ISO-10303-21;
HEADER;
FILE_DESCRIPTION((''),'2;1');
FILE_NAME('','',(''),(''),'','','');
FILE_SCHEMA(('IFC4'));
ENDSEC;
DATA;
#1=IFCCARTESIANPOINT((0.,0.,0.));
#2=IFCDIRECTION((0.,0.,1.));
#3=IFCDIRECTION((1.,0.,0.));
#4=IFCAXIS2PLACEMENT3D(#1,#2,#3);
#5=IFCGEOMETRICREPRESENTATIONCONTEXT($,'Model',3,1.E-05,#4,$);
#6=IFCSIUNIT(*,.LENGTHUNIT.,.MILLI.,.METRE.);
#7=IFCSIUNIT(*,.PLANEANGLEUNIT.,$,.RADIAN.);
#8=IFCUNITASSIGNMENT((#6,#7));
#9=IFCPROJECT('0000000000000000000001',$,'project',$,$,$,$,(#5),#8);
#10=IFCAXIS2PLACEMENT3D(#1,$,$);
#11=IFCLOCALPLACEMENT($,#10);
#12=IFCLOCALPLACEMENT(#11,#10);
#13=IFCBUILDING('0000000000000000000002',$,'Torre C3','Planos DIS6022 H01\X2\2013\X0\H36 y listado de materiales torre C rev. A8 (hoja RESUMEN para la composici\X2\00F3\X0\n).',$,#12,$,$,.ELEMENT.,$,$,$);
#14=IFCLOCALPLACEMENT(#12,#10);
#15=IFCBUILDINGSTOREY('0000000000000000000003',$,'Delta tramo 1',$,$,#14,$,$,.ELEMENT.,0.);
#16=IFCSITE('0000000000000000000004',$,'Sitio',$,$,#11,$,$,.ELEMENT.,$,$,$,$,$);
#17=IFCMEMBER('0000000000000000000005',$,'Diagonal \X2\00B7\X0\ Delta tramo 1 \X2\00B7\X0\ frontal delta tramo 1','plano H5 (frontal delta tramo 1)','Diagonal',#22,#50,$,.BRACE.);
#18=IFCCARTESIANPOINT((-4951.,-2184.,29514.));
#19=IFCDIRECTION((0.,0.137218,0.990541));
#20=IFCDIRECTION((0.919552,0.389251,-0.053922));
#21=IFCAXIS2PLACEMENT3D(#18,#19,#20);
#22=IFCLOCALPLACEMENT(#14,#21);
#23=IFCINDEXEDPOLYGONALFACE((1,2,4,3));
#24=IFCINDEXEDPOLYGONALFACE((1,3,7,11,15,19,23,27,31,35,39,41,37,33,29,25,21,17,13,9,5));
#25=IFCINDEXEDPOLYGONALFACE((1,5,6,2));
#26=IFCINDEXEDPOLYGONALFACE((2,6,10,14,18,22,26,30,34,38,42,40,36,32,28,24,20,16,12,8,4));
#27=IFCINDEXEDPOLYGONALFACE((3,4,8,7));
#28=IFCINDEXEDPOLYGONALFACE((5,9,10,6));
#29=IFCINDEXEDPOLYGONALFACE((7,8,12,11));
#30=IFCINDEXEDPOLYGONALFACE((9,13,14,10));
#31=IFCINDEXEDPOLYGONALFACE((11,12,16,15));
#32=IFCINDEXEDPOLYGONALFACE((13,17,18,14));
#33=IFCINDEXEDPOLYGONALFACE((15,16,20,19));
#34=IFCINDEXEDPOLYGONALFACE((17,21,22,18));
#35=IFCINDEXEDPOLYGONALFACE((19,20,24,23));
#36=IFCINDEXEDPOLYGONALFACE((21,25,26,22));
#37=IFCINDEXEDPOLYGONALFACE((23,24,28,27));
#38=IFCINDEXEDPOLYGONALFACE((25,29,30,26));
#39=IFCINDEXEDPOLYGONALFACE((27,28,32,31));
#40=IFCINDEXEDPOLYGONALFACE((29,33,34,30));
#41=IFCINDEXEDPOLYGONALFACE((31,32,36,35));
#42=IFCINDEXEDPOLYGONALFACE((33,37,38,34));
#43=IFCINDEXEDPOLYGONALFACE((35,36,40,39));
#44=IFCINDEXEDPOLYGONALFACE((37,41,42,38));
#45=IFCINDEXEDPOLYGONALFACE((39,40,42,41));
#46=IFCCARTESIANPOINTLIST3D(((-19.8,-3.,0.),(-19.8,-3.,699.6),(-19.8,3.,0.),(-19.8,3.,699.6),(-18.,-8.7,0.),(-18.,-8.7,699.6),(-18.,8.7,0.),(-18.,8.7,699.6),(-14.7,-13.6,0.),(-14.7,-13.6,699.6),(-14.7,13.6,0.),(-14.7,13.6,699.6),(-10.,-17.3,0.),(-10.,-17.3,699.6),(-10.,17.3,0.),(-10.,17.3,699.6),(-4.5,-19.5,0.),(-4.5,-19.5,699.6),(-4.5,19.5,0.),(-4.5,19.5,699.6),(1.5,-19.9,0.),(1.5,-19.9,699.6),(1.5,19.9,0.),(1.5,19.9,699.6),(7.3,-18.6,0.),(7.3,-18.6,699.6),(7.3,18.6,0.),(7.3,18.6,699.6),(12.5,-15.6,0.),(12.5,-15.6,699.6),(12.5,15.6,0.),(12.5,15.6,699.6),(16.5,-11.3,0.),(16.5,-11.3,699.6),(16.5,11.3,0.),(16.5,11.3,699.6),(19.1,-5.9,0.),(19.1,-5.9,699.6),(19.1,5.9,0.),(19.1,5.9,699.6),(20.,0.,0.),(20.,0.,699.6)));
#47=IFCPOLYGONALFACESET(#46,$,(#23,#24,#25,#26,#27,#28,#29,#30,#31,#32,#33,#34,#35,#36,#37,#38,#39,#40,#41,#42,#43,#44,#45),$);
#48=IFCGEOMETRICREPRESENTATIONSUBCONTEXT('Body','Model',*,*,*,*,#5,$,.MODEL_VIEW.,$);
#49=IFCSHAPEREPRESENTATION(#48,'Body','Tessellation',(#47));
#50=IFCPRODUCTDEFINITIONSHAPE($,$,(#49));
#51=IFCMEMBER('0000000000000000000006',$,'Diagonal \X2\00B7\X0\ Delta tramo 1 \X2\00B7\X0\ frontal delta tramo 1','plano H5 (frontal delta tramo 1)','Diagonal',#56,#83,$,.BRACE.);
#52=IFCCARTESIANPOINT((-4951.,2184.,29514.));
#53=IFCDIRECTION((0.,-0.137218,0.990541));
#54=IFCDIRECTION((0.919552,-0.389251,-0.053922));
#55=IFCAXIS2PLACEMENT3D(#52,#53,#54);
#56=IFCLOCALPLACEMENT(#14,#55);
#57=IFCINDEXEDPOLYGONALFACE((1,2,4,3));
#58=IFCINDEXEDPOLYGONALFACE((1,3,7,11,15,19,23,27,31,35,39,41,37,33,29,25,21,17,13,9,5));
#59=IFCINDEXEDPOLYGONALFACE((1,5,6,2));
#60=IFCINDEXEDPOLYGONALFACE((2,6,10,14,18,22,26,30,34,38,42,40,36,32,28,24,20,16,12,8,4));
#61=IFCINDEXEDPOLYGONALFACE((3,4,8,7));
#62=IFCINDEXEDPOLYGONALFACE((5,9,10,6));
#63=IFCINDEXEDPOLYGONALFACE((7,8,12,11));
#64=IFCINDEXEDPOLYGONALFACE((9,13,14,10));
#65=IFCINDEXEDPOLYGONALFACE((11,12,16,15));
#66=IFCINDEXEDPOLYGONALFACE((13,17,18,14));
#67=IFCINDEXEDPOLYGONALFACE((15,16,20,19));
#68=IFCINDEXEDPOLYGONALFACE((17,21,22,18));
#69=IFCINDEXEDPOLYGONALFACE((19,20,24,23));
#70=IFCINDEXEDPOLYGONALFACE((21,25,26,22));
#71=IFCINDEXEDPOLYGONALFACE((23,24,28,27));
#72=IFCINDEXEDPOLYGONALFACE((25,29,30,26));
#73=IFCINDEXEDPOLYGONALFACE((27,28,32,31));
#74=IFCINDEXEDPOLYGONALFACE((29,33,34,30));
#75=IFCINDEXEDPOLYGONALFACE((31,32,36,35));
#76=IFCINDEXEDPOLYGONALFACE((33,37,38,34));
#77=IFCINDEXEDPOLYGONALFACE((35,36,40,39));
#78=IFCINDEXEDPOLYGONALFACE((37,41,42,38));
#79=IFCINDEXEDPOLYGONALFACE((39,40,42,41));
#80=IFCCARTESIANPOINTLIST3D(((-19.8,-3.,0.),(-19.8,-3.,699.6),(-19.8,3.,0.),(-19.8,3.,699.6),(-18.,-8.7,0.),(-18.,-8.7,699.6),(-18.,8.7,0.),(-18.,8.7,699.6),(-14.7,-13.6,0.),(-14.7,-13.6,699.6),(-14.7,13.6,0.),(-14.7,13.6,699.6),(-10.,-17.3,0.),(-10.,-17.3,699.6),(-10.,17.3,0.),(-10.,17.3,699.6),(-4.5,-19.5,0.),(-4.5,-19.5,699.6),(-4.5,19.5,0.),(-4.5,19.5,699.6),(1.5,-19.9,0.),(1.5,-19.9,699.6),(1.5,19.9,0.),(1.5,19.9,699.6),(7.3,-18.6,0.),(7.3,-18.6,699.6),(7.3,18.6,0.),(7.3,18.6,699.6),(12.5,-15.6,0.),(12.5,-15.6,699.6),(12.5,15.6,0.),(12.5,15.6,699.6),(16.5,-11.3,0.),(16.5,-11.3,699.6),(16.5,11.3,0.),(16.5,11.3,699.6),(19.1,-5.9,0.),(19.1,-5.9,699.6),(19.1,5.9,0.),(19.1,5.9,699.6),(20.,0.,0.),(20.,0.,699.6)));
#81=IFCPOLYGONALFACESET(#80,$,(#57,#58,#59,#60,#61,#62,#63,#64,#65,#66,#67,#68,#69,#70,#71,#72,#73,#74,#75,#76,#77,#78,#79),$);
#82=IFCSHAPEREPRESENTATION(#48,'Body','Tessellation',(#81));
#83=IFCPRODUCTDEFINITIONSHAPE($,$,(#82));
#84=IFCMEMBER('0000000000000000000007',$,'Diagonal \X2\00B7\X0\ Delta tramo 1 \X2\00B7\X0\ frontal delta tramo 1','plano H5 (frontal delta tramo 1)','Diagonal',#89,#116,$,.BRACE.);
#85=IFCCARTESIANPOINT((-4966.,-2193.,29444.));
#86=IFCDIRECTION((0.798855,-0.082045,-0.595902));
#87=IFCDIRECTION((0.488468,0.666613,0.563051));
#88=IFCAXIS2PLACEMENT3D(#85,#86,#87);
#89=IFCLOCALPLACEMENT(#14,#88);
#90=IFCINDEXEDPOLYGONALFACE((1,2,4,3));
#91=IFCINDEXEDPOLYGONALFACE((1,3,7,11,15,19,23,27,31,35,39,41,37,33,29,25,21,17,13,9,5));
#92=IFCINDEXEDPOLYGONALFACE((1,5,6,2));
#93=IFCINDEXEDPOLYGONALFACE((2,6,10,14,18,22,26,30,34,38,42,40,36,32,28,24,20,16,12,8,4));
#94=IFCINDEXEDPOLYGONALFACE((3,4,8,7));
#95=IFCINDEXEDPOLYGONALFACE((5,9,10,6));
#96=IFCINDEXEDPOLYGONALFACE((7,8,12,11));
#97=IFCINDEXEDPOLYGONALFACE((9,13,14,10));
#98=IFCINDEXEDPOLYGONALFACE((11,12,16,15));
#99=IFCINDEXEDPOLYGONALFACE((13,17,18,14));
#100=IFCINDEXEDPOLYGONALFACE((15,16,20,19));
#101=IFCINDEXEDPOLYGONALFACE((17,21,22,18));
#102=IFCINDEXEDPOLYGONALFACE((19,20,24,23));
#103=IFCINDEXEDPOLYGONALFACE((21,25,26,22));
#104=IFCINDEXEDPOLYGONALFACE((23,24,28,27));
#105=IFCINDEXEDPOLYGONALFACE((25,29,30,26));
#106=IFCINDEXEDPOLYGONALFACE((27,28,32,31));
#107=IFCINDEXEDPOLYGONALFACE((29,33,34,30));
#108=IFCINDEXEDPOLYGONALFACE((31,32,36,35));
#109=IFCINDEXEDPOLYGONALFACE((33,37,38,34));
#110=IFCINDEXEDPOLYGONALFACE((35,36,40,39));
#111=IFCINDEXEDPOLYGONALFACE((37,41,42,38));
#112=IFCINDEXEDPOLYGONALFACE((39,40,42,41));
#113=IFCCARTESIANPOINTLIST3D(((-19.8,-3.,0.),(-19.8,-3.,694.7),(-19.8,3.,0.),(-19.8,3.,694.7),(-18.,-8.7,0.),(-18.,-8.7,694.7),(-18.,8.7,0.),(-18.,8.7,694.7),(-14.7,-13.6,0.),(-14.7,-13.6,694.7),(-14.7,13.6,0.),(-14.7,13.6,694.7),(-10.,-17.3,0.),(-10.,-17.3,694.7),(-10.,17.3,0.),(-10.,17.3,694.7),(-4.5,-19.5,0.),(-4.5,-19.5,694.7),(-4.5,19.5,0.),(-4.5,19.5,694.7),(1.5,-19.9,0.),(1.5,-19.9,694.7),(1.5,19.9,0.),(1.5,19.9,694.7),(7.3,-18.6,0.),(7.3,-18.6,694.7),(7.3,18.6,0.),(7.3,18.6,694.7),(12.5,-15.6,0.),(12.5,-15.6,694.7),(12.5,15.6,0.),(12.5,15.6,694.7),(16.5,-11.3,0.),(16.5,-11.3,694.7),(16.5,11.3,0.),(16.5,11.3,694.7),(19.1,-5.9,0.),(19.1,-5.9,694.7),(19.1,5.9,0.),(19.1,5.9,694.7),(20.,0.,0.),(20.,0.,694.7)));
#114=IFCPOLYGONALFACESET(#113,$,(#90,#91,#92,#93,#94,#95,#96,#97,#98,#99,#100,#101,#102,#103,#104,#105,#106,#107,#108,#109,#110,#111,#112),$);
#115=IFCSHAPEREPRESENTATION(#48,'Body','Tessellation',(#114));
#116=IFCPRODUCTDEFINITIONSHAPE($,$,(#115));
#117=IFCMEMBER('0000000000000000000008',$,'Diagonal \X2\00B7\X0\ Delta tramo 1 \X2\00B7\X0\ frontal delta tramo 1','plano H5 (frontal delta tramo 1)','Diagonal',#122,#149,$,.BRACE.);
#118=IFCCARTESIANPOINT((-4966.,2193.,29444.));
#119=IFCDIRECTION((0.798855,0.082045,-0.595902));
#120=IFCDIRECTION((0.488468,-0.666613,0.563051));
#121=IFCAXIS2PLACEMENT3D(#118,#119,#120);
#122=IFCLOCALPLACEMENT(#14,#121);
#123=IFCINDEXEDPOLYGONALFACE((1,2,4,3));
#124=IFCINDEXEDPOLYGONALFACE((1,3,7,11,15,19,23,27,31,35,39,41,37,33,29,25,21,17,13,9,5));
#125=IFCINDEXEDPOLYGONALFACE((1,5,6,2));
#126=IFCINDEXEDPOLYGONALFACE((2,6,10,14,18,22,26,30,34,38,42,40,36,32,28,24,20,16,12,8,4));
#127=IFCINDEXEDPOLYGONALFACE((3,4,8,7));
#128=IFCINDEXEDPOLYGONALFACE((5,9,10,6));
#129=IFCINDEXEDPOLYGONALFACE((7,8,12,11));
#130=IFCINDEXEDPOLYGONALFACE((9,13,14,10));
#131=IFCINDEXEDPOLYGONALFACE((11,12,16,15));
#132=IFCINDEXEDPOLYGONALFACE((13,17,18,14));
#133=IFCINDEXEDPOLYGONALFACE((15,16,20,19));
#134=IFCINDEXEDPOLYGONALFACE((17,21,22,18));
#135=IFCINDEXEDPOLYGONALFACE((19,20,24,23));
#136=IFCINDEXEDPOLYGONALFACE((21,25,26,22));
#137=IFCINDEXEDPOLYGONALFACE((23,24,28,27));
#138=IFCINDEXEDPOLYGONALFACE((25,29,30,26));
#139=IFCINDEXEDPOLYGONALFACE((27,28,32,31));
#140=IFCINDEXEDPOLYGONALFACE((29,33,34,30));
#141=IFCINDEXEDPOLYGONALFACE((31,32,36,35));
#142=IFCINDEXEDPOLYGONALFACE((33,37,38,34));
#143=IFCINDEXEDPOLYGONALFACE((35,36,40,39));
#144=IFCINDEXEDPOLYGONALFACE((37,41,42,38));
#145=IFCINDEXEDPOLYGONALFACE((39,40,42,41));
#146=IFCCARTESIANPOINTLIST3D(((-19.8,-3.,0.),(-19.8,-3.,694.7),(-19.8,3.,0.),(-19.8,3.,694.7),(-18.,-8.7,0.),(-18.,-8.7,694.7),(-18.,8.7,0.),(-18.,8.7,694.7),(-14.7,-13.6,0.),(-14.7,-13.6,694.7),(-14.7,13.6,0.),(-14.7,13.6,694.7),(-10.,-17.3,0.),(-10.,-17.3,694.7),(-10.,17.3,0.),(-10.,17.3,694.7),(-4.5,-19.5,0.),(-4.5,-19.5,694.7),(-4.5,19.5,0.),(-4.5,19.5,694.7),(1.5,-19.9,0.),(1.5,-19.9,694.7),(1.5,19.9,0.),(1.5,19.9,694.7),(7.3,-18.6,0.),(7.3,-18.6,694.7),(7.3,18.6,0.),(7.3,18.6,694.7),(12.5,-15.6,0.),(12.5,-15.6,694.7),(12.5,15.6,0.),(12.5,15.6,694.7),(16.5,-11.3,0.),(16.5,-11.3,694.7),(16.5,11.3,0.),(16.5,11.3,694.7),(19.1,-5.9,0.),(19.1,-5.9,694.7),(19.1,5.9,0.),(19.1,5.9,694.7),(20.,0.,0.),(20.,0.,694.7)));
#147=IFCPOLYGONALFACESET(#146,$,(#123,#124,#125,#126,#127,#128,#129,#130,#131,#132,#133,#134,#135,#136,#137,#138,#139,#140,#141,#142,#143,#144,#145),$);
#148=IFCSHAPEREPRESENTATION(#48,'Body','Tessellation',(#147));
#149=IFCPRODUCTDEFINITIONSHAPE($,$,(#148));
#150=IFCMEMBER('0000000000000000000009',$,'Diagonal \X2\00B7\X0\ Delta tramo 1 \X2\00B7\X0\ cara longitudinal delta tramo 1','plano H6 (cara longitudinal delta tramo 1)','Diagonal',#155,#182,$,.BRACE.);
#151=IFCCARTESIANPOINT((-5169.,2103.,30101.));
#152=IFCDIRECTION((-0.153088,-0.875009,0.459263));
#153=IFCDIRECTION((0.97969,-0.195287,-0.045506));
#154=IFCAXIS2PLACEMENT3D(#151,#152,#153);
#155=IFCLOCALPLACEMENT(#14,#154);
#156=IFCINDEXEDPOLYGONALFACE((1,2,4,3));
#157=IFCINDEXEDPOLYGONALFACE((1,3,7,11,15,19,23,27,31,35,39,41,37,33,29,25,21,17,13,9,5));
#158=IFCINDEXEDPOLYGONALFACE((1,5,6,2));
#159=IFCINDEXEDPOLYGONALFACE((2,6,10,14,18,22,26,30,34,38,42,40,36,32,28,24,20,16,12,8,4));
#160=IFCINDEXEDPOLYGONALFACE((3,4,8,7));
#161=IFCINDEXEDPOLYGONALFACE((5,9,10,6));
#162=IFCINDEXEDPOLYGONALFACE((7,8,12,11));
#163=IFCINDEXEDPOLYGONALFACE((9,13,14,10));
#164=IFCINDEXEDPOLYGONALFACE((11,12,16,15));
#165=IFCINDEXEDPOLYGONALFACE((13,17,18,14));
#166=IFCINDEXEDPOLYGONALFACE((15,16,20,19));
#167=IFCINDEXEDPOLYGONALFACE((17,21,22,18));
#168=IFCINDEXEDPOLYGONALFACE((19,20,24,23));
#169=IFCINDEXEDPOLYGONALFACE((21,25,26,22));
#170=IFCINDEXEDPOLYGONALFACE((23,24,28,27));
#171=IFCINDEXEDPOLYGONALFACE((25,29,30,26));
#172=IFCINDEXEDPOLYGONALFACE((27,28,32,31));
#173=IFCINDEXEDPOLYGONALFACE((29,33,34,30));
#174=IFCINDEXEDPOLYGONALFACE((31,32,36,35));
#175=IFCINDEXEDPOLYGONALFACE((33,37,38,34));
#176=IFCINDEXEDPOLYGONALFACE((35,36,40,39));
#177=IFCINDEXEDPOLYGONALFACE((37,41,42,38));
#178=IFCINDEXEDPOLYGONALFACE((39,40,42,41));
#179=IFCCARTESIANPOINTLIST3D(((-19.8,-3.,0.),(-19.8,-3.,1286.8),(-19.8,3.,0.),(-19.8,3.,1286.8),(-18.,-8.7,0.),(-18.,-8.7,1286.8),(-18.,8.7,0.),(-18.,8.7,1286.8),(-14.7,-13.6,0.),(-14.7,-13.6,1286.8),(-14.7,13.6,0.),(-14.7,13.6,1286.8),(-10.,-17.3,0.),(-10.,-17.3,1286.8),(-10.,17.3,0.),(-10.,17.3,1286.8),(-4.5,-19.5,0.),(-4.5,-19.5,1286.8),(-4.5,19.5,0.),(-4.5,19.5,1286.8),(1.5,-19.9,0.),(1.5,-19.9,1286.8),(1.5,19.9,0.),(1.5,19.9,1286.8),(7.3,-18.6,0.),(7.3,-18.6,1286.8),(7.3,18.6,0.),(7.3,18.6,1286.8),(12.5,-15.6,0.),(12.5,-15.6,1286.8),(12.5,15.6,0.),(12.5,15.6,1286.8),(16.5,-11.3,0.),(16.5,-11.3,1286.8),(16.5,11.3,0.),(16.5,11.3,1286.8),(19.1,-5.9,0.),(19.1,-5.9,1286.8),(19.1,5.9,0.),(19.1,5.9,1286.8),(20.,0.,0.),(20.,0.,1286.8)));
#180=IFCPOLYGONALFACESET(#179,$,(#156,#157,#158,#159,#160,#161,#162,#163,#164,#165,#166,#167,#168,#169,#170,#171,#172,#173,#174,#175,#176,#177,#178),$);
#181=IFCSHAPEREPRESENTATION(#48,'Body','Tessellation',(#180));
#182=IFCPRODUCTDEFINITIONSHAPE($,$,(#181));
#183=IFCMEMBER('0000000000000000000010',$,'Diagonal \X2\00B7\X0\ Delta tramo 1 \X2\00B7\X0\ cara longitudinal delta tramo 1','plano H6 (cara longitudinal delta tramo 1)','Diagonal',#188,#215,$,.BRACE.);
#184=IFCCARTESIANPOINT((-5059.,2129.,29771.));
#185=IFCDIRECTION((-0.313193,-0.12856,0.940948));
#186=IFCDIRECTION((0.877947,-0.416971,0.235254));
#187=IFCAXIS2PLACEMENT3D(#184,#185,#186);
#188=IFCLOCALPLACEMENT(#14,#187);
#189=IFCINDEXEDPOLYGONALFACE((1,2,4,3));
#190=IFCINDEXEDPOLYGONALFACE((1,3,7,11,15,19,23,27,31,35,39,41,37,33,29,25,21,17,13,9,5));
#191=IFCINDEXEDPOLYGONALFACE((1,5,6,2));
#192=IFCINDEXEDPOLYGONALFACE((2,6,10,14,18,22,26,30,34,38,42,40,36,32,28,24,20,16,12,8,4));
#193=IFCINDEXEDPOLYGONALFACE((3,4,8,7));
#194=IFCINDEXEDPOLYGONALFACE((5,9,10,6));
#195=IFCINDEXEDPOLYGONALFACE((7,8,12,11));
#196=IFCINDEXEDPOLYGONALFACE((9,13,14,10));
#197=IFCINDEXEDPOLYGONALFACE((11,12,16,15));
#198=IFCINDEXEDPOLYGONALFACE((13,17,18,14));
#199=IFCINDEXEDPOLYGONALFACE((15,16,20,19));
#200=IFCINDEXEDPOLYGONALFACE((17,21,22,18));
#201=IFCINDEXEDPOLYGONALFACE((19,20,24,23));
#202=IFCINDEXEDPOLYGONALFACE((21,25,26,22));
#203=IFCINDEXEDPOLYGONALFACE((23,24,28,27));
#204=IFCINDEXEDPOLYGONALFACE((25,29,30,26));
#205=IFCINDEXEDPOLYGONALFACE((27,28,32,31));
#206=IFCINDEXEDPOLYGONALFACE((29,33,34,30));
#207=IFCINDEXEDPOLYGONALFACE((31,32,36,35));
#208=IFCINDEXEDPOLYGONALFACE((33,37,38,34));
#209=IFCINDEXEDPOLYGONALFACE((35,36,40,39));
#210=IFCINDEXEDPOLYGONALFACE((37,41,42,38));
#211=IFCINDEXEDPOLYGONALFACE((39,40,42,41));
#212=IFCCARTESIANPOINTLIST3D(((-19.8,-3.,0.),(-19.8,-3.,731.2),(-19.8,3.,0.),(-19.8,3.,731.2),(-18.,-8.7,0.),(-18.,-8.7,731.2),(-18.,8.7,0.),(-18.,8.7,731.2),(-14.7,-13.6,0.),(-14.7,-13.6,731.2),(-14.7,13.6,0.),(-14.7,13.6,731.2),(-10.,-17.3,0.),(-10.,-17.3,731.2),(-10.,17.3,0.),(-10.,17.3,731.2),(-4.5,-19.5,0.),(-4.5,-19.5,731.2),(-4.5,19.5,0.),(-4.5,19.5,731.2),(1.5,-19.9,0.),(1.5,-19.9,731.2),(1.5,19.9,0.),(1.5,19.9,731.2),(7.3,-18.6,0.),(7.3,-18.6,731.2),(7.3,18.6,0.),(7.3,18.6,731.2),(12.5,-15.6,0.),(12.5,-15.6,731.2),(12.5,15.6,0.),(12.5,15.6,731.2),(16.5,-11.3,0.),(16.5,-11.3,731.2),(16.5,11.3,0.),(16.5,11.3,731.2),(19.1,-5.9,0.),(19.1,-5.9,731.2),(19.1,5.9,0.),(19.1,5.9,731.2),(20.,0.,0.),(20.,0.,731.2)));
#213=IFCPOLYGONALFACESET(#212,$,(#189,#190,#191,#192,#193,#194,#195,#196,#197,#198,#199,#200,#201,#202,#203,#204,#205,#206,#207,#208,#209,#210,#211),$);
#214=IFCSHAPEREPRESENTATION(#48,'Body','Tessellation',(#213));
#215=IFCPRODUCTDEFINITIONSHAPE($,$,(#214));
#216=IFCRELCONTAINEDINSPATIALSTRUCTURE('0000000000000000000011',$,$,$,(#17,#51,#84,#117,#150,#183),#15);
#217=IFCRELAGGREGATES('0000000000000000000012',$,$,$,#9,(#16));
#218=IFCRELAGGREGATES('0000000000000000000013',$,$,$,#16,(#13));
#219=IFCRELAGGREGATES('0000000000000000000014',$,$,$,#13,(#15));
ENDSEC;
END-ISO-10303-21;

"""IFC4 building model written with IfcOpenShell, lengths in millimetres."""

from ifc_helpers import new_model, si_unit, frame, origin, origin_with_axes, place, context, subcontext, project, spatial, circle, extrude, element, save


model = new_model("IFC4")

# Units and contexts
model_context = context("Model", 3, precision=1e-05, world=origin_with_axes())
body_context = subcontext(model_context, "Body", "Model", "MODEL_VIEW")
ifc_project = project(units=[si_unit("LENGTHUNIT", "METRE", prefix="MILLI"), si_unit("PLANEANGLEUNIT", "RADIAN")], contexts=[model_context])

# Site, building, storey
site_placement = place(None, origin())
site = spatial("IfcSite", under=ifc_project, at=site_placement, Name="Sitio", CompositionType="ELEMENT")
building_placement = place(site_placement, origin())
building = spatial("IfcBuilding", under=site, at=building_placement, Name="Torre C3", Description="Planos DIS6022 H01–H36 y listado de materiales torre C rev. A8 (hoja RESUMEN para la composición).", CompositionType="ELEMENT")
storey_placement = place(building_placement, origin())
storey = spatial("IfcBuildingStorey", under=building, at=storey_placement, Name="Delta tramo 1", CompositionType="ELEMENT", Elevation=0.0)

# Members
for number, where, z_axis, x_axis, name in (
    (1, (-4951.0, -2184.0, 29514.0), (0.0, 0.137218, 0.990541), (0.919552, 0.389251, -0.053922), "Diagonal · Delta tramo 1 · frontal delta tramo 1"),
    (2, (-4951.0, 2184.0, 29514.0), (0.0, -0.137218, 0.990541), (0.919552, -0.389251, -0.053922), "Diagonal · Delta tramo 1 · frontal delta tramo 1"),
):
    element("IfcMember", number, at=place(storey_placement, frame(where, z_axis=z_axis, x_axis=x_axis)), inside=storey, Name=name, Description="plano H5 (frontal delta tramo 1)", ObjectType="Diagonal", PredefinedType="BRACE", context=body_context, shape_type="SweptSolid", body=[
        extrude(circle(Radius=20.0), None, (0.0, 0.0, 1.0), 699.6),
    ])
for number, where, z_axis, x_axis, name in (
    (3, (-4966.0, -2193.0, 29444.0), (0.798855, -0.082045, -0.595902), (0.488468, 0.666613, 0.563051), "Diagonal · Delta tramo 1 · frontal delta tramo 1"),
    (4, (-4966.0, 2193.0, 29444.0), (0.798855, 0.082045, -0.595902), (0.488468, -0.666613, 0.563051), "Diagonal · Delta tramo 1 · frontal delta tramo 1"),
):
    element("IfcMember", number, at=place(storey_placement, frame(where, z_axis=z_axis, x_axis=x_axis)), inside=storey, Name=name, Description="plano H5 (frontal delta tramo 1)", ObjectType="Diagonal", PredefinedType="BRACE", context=body_context, shape_type="SweptSolid", body=[
        extrude(circle(Radius=20.0), None, (0.0, 0.0, 1.0), 694.7),
    ])
member_1_placement = place(storey_placement, frame((-5169.0, 2103.0, 30101.0), z_axis=(-0.153088, -0.875009, 0.459263), x_axis=(0.97969, -0.195287, -0.045506)))
element("IfcMember", 5, at=member_1_placement, inside=storey, Name="Diagonal · Delta tramo 1 · cara longitudinal delta tramo 1", Description="plano H6 (cara longitudinal delta tramo 1)", ObjectType="Diagonal", PredefinedType="BRACE", context=body_context, shape_type="SweptSolid", body=[
    extrude(circle(Radius=20.0), None, (0.0, 0.0, 1.0), 1286.8),
])
member_2_placement = place(storey_placement, frame((-5059.0, 2129.0, 29771.0), z_axis=(-0.313193, -0.12856, 0.940948), x_axis=(0.877947, -0.416971, 0.235254)))
element("IfcMember", 6, at=member_2_placement, inside=storey, Name="Diagonal · Delta tramo 1 · cara longitudinal delta tramo 1", Description="plano H6 (cara longitudinal delta tramo 1)", ObjectType="Diagonal", PredefinedType="BRACE", context=body_context, shape_type="SweptSolid", body=[
    extrude(circle(Radius=20.0), None, (0.0, 0.0, 1.0), 731.2),
])

save(model, "model.ifc")
